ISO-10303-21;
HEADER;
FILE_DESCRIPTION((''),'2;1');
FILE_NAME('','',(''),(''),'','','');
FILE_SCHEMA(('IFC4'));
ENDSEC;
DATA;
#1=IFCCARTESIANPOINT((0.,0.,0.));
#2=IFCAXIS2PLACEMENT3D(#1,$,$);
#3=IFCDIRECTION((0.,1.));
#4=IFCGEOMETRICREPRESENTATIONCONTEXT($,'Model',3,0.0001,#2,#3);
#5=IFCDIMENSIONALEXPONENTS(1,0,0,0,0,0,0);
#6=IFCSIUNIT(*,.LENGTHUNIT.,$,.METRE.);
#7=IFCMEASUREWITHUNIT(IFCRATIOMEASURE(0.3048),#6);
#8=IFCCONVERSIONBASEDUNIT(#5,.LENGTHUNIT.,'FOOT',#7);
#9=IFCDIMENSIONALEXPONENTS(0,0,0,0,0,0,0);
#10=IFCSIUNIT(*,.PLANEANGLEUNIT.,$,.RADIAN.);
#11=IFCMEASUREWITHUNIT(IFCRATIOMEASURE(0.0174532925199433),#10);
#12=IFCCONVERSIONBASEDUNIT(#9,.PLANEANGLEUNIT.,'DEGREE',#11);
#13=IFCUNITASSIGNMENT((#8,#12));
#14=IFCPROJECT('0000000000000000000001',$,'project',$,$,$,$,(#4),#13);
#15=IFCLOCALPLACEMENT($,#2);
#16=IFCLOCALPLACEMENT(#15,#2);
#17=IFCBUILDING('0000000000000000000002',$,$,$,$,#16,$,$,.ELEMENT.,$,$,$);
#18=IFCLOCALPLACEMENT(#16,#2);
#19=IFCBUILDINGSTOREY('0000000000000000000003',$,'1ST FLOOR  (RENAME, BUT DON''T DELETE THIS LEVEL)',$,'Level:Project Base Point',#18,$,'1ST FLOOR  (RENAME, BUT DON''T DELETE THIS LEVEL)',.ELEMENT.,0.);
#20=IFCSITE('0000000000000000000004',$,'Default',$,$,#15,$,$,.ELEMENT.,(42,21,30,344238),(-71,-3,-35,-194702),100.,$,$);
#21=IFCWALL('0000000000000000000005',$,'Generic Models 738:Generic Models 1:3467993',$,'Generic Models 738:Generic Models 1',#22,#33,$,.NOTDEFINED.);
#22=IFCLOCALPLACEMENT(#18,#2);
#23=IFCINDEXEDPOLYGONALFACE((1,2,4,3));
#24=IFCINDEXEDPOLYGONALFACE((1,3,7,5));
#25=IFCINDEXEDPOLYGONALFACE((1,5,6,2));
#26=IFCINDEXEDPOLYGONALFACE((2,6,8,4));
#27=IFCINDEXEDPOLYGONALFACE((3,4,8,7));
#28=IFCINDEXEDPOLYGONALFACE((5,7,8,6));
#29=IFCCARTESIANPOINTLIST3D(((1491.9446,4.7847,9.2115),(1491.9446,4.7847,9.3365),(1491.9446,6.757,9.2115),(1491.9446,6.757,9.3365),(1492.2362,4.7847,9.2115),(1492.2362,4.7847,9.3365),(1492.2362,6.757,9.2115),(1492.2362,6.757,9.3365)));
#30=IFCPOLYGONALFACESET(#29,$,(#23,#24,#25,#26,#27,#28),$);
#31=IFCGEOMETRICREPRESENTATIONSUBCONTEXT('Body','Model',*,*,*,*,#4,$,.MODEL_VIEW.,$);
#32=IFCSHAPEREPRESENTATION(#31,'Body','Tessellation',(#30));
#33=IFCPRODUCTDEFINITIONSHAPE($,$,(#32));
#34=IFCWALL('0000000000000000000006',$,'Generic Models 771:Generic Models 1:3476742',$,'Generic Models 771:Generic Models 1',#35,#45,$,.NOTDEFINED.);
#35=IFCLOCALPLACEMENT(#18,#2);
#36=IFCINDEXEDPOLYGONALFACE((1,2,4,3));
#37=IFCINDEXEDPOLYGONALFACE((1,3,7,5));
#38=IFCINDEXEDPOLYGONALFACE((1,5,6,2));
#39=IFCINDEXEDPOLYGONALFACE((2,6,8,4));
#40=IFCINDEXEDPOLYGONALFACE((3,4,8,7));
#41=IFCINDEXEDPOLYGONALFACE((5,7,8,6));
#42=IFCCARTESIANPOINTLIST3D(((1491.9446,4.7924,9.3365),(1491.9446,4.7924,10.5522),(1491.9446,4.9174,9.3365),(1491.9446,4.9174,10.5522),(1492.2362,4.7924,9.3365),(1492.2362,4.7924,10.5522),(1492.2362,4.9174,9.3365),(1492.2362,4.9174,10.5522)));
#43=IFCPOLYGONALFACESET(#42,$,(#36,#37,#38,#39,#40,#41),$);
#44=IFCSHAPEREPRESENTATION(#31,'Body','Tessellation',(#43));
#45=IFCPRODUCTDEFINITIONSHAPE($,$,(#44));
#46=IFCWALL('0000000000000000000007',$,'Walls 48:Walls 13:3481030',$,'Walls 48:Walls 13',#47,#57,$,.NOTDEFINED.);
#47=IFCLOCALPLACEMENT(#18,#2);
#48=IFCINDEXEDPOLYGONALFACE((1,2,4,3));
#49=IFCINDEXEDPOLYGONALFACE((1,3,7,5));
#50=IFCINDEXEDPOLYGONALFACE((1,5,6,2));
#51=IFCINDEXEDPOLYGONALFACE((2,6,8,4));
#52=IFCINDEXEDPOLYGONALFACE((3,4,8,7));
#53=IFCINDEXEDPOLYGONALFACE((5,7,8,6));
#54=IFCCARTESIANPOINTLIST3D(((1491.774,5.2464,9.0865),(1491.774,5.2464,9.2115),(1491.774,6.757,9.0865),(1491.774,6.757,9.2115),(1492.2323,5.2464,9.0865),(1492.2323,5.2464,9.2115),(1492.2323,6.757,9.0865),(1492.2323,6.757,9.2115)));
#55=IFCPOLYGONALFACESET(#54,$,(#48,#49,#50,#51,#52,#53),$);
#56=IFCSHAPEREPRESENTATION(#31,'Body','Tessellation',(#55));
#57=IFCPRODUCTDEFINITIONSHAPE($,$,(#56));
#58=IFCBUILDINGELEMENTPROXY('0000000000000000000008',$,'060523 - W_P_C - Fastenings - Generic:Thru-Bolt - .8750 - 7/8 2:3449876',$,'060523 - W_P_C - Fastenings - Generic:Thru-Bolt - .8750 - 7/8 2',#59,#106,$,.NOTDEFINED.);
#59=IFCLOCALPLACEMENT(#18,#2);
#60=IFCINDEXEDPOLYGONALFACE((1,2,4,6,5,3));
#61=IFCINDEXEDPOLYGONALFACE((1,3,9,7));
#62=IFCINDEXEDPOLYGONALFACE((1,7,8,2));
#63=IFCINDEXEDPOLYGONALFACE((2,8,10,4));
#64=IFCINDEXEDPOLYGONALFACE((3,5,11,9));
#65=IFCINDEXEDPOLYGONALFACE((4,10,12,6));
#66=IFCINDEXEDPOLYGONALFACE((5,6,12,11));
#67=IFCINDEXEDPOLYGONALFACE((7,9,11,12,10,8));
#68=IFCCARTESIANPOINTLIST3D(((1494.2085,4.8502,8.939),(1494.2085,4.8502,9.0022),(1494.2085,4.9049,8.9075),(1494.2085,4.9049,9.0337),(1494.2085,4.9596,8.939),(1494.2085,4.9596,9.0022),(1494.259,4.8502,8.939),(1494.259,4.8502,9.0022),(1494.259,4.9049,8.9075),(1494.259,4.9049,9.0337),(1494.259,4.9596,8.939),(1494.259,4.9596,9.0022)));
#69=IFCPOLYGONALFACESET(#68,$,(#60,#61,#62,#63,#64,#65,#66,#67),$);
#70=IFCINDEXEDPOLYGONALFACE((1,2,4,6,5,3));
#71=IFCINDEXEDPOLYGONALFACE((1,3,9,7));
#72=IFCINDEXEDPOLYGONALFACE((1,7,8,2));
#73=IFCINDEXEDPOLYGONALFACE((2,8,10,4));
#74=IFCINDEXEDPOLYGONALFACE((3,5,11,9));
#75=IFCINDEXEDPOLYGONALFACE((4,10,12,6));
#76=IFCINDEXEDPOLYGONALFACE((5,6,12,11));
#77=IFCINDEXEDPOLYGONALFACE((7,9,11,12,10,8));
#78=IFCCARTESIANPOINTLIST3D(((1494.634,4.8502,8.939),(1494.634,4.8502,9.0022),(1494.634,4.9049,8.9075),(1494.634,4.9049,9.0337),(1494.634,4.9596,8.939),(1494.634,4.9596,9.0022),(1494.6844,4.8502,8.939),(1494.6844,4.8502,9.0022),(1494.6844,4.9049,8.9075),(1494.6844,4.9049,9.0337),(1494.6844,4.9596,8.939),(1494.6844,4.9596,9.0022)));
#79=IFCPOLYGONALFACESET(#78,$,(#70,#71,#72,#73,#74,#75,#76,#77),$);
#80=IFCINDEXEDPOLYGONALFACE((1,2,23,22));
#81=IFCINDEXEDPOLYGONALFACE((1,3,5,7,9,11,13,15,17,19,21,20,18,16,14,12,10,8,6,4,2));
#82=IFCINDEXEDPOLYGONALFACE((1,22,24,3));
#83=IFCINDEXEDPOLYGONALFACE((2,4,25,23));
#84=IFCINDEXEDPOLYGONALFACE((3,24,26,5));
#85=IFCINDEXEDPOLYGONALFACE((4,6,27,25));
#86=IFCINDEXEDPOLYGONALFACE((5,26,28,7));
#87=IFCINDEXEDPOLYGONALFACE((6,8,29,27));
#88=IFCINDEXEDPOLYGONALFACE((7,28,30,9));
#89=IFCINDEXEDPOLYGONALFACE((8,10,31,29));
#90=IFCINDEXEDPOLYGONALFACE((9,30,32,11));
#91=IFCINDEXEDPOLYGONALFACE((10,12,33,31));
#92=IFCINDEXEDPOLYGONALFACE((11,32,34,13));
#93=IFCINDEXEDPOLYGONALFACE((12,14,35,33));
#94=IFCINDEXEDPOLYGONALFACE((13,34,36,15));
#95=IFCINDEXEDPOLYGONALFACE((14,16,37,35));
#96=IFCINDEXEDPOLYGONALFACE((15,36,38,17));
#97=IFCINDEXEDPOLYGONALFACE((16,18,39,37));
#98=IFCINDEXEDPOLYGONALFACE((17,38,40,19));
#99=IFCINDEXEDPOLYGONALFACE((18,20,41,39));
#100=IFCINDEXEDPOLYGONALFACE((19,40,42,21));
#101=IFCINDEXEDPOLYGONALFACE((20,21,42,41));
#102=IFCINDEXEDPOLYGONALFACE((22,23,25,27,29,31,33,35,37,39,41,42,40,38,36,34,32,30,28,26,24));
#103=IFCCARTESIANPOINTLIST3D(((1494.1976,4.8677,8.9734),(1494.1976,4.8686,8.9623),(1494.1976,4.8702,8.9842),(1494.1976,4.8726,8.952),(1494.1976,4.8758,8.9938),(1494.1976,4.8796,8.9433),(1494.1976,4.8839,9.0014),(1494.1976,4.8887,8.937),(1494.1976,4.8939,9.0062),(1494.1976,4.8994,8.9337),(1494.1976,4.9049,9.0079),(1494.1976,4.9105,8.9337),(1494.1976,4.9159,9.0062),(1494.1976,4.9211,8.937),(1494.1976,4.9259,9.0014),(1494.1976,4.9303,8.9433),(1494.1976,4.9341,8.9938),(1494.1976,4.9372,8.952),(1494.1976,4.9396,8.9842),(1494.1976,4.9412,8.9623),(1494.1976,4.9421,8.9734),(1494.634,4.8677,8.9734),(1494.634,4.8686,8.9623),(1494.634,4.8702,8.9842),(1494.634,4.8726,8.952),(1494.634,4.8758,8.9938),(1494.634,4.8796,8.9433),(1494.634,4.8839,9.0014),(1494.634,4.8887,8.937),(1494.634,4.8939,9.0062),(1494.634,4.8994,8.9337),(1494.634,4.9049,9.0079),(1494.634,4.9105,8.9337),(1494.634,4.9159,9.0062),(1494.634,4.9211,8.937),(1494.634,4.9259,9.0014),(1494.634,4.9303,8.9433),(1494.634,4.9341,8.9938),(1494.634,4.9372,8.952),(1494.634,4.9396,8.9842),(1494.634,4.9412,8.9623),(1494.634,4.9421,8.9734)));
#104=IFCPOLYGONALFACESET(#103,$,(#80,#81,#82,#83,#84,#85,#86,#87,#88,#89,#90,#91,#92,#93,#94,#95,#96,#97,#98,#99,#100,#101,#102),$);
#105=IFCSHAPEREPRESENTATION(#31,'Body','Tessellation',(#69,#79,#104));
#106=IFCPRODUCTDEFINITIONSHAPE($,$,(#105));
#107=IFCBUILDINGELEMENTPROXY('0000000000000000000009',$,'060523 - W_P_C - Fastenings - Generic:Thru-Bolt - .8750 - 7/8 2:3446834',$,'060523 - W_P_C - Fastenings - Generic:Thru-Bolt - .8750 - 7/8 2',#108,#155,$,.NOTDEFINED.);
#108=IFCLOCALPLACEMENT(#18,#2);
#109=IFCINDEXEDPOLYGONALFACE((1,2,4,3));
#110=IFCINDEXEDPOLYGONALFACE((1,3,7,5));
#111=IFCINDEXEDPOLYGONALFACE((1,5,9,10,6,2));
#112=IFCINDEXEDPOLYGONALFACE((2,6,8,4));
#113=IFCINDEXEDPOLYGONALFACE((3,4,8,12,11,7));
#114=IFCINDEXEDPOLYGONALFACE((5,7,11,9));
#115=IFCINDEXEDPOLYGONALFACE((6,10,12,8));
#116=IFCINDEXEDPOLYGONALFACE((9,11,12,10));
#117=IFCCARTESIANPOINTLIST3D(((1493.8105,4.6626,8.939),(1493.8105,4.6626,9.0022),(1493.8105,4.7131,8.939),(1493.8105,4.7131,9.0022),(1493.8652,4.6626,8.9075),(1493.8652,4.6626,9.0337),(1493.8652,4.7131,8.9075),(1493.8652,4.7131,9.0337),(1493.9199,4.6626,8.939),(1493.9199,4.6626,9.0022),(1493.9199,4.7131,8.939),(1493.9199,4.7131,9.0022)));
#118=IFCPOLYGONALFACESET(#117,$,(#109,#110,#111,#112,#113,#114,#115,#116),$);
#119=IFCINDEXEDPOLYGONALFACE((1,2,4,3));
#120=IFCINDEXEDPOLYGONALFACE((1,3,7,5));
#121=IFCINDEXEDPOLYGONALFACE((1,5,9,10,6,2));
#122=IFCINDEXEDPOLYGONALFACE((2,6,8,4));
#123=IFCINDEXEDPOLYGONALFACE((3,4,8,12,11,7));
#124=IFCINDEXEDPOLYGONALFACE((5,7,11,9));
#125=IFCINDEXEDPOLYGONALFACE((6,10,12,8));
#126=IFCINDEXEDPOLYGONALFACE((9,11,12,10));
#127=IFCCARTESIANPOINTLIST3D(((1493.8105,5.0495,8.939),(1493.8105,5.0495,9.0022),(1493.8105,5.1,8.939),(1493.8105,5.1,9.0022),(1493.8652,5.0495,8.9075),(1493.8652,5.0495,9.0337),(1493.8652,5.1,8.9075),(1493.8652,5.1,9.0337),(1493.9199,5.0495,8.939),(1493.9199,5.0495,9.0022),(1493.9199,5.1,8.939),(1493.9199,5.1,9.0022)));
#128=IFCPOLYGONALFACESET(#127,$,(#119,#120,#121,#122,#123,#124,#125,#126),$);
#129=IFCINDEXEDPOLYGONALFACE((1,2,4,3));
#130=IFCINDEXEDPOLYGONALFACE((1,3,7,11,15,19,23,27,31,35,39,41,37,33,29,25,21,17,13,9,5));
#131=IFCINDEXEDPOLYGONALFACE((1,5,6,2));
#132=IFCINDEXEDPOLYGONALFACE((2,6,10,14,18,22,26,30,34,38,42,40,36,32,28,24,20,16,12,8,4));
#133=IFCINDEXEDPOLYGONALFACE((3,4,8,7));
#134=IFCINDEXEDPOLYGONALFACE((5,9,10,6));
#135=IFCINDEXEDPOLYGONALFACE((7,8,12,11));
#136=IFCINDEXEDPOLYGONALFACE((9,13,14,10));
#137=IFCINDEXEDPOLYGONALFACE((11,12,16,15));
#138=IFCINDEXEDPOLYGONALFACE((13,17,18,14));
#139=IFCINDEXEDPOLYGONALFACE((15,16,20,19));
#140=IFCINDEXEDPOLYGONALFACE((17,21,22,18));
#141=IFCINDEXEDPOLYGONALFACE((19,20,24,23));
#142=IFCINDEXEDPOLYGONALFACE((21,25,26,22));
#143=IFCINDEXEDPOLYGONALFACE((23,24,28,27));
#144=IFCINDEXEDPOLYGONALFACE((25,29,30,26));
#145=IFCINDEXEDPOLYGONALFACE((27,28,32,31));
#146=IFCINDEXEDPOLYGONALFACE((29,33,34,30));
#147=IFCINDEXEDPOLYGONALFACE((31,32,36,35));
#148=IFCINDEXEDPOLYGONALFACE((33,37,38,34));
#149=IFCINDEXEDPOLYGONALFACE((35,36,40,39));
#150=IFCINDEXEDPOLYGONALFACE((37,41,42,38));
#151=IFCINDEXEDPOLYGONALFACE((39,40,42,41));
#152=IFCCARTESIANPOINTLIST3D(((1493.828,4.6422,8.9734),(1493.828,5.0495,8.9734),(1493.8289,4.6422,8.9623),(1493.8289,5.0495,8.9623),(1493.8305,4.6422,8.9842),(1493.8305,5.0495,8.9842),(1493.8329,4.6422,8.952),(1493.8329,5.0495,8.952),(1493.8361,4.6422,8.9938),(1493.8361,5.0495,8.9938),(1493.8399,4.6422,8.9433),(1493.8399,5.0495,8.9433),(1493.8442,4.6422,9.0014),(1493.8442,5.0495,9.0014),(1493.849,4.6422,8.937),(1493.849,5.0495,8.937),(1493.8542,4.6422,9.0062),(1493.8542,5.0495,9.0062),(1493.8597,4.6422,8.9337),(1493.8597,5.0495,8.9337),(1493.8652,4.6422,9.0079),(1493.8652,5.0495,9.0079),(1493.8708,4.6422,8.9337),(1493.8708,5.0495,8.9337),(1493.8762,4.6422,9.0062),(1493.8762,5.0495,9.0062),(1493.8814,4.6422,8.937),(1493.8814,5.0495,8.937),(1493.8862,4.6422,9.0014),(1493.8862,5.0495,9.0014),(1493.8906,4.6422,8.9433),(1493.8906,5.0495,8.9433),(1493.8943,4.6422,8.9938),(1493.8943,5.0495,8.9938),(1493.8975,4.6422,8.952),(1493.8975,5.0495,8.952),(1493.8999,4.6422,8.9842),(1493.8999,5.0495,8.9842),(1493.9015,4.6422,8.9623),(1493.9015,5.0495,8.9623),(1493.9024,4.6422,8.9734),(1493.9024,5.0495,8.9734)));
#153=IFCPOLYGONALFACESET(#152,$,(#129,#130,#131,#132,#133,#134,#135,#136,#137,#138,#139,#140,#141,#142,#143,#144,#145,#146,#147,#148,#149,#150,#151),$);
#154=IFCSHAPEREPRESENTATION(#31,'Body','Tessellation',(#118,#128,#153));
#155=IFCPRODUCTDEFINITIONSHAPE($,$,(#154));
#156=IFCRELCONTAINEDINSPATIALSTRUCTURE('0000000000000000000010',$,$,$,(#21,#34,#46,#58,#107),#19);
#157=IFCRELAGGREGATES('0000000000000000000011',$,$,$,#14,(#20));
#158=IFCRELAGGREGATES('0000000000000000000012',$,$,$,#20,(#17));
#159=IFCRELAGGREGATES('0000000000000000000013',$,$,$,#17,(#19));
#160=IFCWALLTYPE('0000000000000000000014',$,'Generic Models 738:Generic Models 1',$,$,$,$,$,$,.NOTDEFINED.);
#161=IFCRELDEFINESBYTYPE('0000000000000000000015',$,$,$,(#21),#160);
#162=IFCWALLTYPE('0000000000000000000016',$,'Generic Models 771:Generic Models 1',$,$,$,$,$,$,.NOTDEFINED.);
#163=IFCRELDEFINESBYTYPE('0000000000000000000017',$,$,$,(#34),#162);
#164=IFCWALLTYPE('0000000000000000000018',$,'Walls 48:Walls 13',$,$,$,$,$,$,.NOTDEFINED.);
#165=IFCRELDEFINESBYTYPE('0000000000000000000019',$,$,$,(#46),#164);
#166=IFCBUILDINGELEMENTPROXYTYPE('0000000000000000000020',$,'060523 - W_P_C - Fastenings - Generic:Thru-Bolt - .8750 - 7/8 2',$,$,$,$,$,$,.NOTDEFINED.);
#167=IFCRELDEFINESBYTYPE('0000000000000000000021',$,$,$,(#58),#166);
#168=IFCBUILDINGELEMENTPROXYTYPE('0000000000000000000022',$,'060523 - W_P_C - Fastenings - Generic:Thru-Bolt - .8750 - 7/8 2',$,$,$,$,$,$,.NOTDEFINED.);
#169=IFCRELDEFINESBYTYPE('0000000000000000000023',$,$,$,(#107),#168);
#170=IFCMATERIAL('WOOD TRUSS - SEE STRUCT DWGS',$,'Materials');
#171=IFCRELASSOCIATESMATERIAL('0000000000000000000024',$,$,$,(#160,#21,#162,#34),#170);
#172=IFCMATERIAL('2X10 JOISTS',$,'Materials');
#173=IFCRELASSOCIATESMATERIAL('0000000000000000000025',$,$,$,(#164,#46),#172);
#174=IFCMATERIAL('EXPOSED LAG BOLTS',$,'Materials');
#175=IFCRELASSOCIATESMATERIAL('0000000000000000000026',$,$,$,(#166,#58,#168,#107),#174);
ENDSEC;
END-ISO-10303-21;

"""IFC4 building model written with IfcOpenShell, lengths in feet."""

from ifc_helpers import new_model, entity, si_unit, converted_unit, direction, frame, frame_2d, origin, place, context, subcontext, project, spatial, polyline, rectangle, circle, outline, extrude, source, transform, mapped, material, type_object, type_shapes, element, save


model = new_model("IFC4")

# Units and contexts
model_context = context("Model", 3, precision=0.0001, world=origin(), true_north=direction((0.0, 1.0)))
body_context = subcontext(model_context, "Body", "Model", "MODEL_VIEW")
ifc_project = project(units=[converted_unit("LENGTHUNIT", "FOOT", entity("IfcRatioMeasure", 0.3048), si_unit("LENGTHUNIT", "METRE"), dimensions=[1, 0, 0, 0, 0, 0, 0]), converted_unit("PLANEANGLEUNIT", "DEGREE", entity("IfcRatioMeasure", 0.0174532925199433), si_unit("PLANEANGLEUNIT", "RADIAN"), dimensions=[0, 0, 0, 0, 0, 0, 0])], contexts=[model_context])

# Site, building, storey
site_placement = place(None, origin())
site = spatial("IfcSite", under=ifc_project, at=site_placement, Name="Default", CompositionType="ELEMENT", RefLatitude=(42, 21, 30, 344238), RefLongitude=(-71, -3, -35, -194702), RefElevation=100.0)
building_placement = place(site_placement, origin())
building = spatial("IfcBuilding", under=site, at=building_placement, CompositionType="ELEMENT")
storey_placement = place(building_placement, origin())
storey = spatial("IfcBuildingStorey", under=building, at=storey_placement, Name="1ST FLOOR  (RENAME, BUT DON'T DELETE THIS LEVEL)", ObjectType="Level:Project Base Point", LongName="1ST FLOOR  (RENAME, BUT DON'T DELETE THIS LEVEL)", CompositionType="ELEMENT", Elevation=0.0)

# Walls
ifc_material_1 = material(Name="WOOD TRUSS - SEE STRUCT DWGS", Category="Materials")
wall_type_1 = type_object("IfcWallType", Name="Generic Models 738:Generic Models 1", PredefinedType="NOTDEFINED", material=ifc_material_1)
wall_1_placement = place(storey_placement, frame((1491.9446, 4.7847, 9.2115), z_axis=(0.0, 0.0, 1.0), x_axis=(0.0, 1.0, 0.0)))
element("IfcWall", 1, at=wall_1_placement, inside=storey, type_object=wall_type_1, material=ifc_material_1, Name="Generic Models 738:Generic Models 1:3467993", ObjectType="Generic Models 738:Generic Models 1", PredefinedType="NOTDEFINED", context=body_context, shape_type="SweptSolid", body=[
    extrude(rectangle(XDim=1.9723, YDim=0.2917, at=frame_2d((0.0, 0.0), x_axis=(1.0, 0.0))), frame((0.9861, -0.1458, 0.0)), (0.0, 0.0, 1.0), 0.125),
])
wall_type_2 = type_object("IfcWallType", Name="Generic Models 771:Generic Models 1", PredefinedType="NOTDEFINED", material=ifc_material_1)
wall_2_placement = place(storey_placement, frame((1491.9446, 4.7924, 9.3365)))
element("IfcWall", 2, at=wall_2_placement, inside=storey, type_object=wall_type_2, material=ifc_material_1, Name="Generic Models 771:Generic Models 1:3476742", ObjectType="Generic Models 771:Generic Models 1", PredefinedType="NOTDEFINED", context=body_context, shape_type="SweptSolid", body=[
    extrude(rectangle(XDim=0.125, YDim=0.2917, at=frame_2d((0.0, 0.0), x_axis=(1.0, 0.0))), frame((0.1458, 0.0625, 0.0), z_axis=(0.0, 0.0, 1.0), x_axis=(0.0, 1.0, 0.0)), (0.0, 0.0, 1.0), 1.2157),
])
ifc_material_2 = material(Name="2X10 JOISTS", Category="Materials")
wall_type_3 = type_object("IfcWallType", Name="Walls 48:Walls 13", PredefinedType="NOTDEFINED", material=ifc_material_2)
wall_3_placement = place(storey_placement, frame((1491.774, 5.2464, 9.0865), z_axis=(0.0, 0.0, 1.0), x_axis=(0.0, 1.0, 0.0)))
element("IfcWall", 3, at=wall_3_placement, inside=storey, type_object=wall_type_3, material=ifc_material_2, Name="Walls 48:Walls 13:3481030", ObjectType="Walls 48:Walls 13", PredefinedType="NOTDEFINED", context=body_context, shape_type="SweptSolid", body=[
    extrude(rectangle(XDim=1.5106, YDim=0.4583, at=frame_2d((0.0, 0.0), x_axis=(1.0, 0.0))), frame((0.7553, -0.2292, 0.0)), (0.0, 0.0, 1.0), 0.125),
])

# Building element proxies
ifc_material_3 = material(Name="EXPOSED LAG BOLTS", Category="Materials")
building_element_proxy_type_1 = type_object("IfcBuildingElementProxyType", Name="060523 - W_P_C - Fastenings - Generic:Thru-Bolt - .8750 - 7/8 2", PredefinedType="NOTDEFINED", material=ifc_material_3)
shared_shape_1 = source(origin(), body_context, "Body", "SweptSolid", [
    extrude(outline(polyline([(-0.0316, -0.0547), (0.0316, -0.0547), (0.0631, 0.0), (0.0316, 0.0547), (-0.0316, 0.0547), (-0.0631, 0.0), (-0.0316, -0.0547)])), frame((0.0, 0.0, -0.4255), z_axis=(0.0, 0.0, 1.0), x_axis=(0.866025, -0.5, 0.0)), (0.0, 0.0, 1.0), 0.0505),
    extrude(outline(polyline([(-0.0316, -0.0547), (0.0316, -0.0547), (0.0631, 0.0), (0.0316, 0.0547), (-0.0316, 0.0547), (-0.0631, 0.0), (-0.0316, -0.0547)])), frame((0.0, 0.0, 0.0), z_axis=(0.0, 0.0, 1.0), x_axis=(0.0, -1.0, 0.0)), (0.0, 0.0, 1.0), 0.0505),
    extrude(circle(Radius=0.0373, at=frame_2d((0.0, 0.0), x_axis=(1.0, 0.0))), frame((0.0, 0.0, -0.4364), z_axis=(0.0, 0.0, 1.0), x_axis=(0.0, 1.0, 0.0)), (0.0, 0.0, 1.0), 0.4364),
])
type_shapes(building_element_proxy_type_1, [shared_shape_1])
proxy_1_placement = place(storey_placement, frame((1494.634, 4.9049, 8.9706), z_axis=(1.0, 0.0, 0.0), x_axis=(0.0, 1.0, 0.0)))
element("IfcBuildingElementProxy", 4, at=proxy_1_placement, inside=storey, type_object=building_element_proxy_type_1, material=ifc_material_3, Name="060523 - W_P_C - Fastenings - Generic:Thru-Bolt - .8750 - 7/8 2:3449876", ObjectType="060523 - W_P_C - Fastenings - Generic:Thru-Bolt - .8750 - 7/8 2", PredefinedType="NOTDEFINED", context=body_context, shape_type="MappedRepresentation", body=[
    mapped(shared_shape_1, transform((0.0, 0.0, 0.0), scale=1.0)),
])
building_element_proxy_type_2 = type_object("IfcBuildingElementProxyType", Name="060523 - W_P_C - Fastenings - Generic:Thru-Bolt - .8750 - 7/8 2", PredefinedType="NOTDEFINED", material=ifc_material_3)
shared_shape_2 = source(origin(), body_context, "Body", "SweptSolid", [
    extrude(outline(polyline([(-0.0316, -0.0547), (0.0316, -0.0547), (0.0631, 0.0), (0.0316, 0.0547), (-0.0316, 0.0547), (-0.0631, 0.0), (-0.0316, -0.0547)])), frame((0.0, 0.0, -0.3869), z_axis=(0.0, 0.0, 1.0), x_axis=(0.866025, -0.5, 0.0)), (0.0, 0.0, 1.0), 0.0505),
    extrude(outline(polyline([(-0.0316, -0.0547), (0.0316, -0.0547), (0.0631, 0.0), (0.0316, 0.0547), (-0.0316, 0.0547), (-0.0631, 0.0), (-0.0316, -0.0547)])), frame((0.0, 0.0, 0.0), z_axis=(0.0, 0.0, 1.0), x_axis=(0.0, -1.0, 0.0)), (0.0, 0.0, 1.0), 0.0505),
    extrude(circle(Radius=0.0373, at=frame_2d((0.0, 0.0), x_axis=(1.0, 0.0))), frame((0.0, 0.0, -0.4073), z_axis=(0.0, 0.0, 1.0), x_axis=(0.0, 1.0, 0.0)), (0.0, 0.0, 1.0), 0.4073),
])
type_shapes(building_element_proxy_type_2, [shared_shape_2])
for number, where, z_axis, x_axis, name in (
    (5, (1493.8652, 5.0495, 8.9706), (0.0, 1.0, 0.0), (-1.0, 0.0, 0.0), "060523 - W_P_C - Fastenings - Generic:Thru-Bolt - .8750 - 7/8 2:3446834"),
):
    element("IfcBuildingElementProxy", number, at=place(storey_placement, frame(where, z_axis=z_axis, x_axis=x_axis)), inside=storey, type_object=building_element_proxy_type_2, material=ifc_material_3, Name=name, ObjectType="060523 - W_P_C - Fastenings - Generic:Thru-Bolt - .8750 - 7/8 2", PredefinedType="NOTDEFINED", context=body_context, shape_type="MappedRepresentation", body=[
        mapped(shared_shape_2, transform((0.0, 0.0, 0.0), scale=1.0)),
    ])

save(model, "model.ifc")
